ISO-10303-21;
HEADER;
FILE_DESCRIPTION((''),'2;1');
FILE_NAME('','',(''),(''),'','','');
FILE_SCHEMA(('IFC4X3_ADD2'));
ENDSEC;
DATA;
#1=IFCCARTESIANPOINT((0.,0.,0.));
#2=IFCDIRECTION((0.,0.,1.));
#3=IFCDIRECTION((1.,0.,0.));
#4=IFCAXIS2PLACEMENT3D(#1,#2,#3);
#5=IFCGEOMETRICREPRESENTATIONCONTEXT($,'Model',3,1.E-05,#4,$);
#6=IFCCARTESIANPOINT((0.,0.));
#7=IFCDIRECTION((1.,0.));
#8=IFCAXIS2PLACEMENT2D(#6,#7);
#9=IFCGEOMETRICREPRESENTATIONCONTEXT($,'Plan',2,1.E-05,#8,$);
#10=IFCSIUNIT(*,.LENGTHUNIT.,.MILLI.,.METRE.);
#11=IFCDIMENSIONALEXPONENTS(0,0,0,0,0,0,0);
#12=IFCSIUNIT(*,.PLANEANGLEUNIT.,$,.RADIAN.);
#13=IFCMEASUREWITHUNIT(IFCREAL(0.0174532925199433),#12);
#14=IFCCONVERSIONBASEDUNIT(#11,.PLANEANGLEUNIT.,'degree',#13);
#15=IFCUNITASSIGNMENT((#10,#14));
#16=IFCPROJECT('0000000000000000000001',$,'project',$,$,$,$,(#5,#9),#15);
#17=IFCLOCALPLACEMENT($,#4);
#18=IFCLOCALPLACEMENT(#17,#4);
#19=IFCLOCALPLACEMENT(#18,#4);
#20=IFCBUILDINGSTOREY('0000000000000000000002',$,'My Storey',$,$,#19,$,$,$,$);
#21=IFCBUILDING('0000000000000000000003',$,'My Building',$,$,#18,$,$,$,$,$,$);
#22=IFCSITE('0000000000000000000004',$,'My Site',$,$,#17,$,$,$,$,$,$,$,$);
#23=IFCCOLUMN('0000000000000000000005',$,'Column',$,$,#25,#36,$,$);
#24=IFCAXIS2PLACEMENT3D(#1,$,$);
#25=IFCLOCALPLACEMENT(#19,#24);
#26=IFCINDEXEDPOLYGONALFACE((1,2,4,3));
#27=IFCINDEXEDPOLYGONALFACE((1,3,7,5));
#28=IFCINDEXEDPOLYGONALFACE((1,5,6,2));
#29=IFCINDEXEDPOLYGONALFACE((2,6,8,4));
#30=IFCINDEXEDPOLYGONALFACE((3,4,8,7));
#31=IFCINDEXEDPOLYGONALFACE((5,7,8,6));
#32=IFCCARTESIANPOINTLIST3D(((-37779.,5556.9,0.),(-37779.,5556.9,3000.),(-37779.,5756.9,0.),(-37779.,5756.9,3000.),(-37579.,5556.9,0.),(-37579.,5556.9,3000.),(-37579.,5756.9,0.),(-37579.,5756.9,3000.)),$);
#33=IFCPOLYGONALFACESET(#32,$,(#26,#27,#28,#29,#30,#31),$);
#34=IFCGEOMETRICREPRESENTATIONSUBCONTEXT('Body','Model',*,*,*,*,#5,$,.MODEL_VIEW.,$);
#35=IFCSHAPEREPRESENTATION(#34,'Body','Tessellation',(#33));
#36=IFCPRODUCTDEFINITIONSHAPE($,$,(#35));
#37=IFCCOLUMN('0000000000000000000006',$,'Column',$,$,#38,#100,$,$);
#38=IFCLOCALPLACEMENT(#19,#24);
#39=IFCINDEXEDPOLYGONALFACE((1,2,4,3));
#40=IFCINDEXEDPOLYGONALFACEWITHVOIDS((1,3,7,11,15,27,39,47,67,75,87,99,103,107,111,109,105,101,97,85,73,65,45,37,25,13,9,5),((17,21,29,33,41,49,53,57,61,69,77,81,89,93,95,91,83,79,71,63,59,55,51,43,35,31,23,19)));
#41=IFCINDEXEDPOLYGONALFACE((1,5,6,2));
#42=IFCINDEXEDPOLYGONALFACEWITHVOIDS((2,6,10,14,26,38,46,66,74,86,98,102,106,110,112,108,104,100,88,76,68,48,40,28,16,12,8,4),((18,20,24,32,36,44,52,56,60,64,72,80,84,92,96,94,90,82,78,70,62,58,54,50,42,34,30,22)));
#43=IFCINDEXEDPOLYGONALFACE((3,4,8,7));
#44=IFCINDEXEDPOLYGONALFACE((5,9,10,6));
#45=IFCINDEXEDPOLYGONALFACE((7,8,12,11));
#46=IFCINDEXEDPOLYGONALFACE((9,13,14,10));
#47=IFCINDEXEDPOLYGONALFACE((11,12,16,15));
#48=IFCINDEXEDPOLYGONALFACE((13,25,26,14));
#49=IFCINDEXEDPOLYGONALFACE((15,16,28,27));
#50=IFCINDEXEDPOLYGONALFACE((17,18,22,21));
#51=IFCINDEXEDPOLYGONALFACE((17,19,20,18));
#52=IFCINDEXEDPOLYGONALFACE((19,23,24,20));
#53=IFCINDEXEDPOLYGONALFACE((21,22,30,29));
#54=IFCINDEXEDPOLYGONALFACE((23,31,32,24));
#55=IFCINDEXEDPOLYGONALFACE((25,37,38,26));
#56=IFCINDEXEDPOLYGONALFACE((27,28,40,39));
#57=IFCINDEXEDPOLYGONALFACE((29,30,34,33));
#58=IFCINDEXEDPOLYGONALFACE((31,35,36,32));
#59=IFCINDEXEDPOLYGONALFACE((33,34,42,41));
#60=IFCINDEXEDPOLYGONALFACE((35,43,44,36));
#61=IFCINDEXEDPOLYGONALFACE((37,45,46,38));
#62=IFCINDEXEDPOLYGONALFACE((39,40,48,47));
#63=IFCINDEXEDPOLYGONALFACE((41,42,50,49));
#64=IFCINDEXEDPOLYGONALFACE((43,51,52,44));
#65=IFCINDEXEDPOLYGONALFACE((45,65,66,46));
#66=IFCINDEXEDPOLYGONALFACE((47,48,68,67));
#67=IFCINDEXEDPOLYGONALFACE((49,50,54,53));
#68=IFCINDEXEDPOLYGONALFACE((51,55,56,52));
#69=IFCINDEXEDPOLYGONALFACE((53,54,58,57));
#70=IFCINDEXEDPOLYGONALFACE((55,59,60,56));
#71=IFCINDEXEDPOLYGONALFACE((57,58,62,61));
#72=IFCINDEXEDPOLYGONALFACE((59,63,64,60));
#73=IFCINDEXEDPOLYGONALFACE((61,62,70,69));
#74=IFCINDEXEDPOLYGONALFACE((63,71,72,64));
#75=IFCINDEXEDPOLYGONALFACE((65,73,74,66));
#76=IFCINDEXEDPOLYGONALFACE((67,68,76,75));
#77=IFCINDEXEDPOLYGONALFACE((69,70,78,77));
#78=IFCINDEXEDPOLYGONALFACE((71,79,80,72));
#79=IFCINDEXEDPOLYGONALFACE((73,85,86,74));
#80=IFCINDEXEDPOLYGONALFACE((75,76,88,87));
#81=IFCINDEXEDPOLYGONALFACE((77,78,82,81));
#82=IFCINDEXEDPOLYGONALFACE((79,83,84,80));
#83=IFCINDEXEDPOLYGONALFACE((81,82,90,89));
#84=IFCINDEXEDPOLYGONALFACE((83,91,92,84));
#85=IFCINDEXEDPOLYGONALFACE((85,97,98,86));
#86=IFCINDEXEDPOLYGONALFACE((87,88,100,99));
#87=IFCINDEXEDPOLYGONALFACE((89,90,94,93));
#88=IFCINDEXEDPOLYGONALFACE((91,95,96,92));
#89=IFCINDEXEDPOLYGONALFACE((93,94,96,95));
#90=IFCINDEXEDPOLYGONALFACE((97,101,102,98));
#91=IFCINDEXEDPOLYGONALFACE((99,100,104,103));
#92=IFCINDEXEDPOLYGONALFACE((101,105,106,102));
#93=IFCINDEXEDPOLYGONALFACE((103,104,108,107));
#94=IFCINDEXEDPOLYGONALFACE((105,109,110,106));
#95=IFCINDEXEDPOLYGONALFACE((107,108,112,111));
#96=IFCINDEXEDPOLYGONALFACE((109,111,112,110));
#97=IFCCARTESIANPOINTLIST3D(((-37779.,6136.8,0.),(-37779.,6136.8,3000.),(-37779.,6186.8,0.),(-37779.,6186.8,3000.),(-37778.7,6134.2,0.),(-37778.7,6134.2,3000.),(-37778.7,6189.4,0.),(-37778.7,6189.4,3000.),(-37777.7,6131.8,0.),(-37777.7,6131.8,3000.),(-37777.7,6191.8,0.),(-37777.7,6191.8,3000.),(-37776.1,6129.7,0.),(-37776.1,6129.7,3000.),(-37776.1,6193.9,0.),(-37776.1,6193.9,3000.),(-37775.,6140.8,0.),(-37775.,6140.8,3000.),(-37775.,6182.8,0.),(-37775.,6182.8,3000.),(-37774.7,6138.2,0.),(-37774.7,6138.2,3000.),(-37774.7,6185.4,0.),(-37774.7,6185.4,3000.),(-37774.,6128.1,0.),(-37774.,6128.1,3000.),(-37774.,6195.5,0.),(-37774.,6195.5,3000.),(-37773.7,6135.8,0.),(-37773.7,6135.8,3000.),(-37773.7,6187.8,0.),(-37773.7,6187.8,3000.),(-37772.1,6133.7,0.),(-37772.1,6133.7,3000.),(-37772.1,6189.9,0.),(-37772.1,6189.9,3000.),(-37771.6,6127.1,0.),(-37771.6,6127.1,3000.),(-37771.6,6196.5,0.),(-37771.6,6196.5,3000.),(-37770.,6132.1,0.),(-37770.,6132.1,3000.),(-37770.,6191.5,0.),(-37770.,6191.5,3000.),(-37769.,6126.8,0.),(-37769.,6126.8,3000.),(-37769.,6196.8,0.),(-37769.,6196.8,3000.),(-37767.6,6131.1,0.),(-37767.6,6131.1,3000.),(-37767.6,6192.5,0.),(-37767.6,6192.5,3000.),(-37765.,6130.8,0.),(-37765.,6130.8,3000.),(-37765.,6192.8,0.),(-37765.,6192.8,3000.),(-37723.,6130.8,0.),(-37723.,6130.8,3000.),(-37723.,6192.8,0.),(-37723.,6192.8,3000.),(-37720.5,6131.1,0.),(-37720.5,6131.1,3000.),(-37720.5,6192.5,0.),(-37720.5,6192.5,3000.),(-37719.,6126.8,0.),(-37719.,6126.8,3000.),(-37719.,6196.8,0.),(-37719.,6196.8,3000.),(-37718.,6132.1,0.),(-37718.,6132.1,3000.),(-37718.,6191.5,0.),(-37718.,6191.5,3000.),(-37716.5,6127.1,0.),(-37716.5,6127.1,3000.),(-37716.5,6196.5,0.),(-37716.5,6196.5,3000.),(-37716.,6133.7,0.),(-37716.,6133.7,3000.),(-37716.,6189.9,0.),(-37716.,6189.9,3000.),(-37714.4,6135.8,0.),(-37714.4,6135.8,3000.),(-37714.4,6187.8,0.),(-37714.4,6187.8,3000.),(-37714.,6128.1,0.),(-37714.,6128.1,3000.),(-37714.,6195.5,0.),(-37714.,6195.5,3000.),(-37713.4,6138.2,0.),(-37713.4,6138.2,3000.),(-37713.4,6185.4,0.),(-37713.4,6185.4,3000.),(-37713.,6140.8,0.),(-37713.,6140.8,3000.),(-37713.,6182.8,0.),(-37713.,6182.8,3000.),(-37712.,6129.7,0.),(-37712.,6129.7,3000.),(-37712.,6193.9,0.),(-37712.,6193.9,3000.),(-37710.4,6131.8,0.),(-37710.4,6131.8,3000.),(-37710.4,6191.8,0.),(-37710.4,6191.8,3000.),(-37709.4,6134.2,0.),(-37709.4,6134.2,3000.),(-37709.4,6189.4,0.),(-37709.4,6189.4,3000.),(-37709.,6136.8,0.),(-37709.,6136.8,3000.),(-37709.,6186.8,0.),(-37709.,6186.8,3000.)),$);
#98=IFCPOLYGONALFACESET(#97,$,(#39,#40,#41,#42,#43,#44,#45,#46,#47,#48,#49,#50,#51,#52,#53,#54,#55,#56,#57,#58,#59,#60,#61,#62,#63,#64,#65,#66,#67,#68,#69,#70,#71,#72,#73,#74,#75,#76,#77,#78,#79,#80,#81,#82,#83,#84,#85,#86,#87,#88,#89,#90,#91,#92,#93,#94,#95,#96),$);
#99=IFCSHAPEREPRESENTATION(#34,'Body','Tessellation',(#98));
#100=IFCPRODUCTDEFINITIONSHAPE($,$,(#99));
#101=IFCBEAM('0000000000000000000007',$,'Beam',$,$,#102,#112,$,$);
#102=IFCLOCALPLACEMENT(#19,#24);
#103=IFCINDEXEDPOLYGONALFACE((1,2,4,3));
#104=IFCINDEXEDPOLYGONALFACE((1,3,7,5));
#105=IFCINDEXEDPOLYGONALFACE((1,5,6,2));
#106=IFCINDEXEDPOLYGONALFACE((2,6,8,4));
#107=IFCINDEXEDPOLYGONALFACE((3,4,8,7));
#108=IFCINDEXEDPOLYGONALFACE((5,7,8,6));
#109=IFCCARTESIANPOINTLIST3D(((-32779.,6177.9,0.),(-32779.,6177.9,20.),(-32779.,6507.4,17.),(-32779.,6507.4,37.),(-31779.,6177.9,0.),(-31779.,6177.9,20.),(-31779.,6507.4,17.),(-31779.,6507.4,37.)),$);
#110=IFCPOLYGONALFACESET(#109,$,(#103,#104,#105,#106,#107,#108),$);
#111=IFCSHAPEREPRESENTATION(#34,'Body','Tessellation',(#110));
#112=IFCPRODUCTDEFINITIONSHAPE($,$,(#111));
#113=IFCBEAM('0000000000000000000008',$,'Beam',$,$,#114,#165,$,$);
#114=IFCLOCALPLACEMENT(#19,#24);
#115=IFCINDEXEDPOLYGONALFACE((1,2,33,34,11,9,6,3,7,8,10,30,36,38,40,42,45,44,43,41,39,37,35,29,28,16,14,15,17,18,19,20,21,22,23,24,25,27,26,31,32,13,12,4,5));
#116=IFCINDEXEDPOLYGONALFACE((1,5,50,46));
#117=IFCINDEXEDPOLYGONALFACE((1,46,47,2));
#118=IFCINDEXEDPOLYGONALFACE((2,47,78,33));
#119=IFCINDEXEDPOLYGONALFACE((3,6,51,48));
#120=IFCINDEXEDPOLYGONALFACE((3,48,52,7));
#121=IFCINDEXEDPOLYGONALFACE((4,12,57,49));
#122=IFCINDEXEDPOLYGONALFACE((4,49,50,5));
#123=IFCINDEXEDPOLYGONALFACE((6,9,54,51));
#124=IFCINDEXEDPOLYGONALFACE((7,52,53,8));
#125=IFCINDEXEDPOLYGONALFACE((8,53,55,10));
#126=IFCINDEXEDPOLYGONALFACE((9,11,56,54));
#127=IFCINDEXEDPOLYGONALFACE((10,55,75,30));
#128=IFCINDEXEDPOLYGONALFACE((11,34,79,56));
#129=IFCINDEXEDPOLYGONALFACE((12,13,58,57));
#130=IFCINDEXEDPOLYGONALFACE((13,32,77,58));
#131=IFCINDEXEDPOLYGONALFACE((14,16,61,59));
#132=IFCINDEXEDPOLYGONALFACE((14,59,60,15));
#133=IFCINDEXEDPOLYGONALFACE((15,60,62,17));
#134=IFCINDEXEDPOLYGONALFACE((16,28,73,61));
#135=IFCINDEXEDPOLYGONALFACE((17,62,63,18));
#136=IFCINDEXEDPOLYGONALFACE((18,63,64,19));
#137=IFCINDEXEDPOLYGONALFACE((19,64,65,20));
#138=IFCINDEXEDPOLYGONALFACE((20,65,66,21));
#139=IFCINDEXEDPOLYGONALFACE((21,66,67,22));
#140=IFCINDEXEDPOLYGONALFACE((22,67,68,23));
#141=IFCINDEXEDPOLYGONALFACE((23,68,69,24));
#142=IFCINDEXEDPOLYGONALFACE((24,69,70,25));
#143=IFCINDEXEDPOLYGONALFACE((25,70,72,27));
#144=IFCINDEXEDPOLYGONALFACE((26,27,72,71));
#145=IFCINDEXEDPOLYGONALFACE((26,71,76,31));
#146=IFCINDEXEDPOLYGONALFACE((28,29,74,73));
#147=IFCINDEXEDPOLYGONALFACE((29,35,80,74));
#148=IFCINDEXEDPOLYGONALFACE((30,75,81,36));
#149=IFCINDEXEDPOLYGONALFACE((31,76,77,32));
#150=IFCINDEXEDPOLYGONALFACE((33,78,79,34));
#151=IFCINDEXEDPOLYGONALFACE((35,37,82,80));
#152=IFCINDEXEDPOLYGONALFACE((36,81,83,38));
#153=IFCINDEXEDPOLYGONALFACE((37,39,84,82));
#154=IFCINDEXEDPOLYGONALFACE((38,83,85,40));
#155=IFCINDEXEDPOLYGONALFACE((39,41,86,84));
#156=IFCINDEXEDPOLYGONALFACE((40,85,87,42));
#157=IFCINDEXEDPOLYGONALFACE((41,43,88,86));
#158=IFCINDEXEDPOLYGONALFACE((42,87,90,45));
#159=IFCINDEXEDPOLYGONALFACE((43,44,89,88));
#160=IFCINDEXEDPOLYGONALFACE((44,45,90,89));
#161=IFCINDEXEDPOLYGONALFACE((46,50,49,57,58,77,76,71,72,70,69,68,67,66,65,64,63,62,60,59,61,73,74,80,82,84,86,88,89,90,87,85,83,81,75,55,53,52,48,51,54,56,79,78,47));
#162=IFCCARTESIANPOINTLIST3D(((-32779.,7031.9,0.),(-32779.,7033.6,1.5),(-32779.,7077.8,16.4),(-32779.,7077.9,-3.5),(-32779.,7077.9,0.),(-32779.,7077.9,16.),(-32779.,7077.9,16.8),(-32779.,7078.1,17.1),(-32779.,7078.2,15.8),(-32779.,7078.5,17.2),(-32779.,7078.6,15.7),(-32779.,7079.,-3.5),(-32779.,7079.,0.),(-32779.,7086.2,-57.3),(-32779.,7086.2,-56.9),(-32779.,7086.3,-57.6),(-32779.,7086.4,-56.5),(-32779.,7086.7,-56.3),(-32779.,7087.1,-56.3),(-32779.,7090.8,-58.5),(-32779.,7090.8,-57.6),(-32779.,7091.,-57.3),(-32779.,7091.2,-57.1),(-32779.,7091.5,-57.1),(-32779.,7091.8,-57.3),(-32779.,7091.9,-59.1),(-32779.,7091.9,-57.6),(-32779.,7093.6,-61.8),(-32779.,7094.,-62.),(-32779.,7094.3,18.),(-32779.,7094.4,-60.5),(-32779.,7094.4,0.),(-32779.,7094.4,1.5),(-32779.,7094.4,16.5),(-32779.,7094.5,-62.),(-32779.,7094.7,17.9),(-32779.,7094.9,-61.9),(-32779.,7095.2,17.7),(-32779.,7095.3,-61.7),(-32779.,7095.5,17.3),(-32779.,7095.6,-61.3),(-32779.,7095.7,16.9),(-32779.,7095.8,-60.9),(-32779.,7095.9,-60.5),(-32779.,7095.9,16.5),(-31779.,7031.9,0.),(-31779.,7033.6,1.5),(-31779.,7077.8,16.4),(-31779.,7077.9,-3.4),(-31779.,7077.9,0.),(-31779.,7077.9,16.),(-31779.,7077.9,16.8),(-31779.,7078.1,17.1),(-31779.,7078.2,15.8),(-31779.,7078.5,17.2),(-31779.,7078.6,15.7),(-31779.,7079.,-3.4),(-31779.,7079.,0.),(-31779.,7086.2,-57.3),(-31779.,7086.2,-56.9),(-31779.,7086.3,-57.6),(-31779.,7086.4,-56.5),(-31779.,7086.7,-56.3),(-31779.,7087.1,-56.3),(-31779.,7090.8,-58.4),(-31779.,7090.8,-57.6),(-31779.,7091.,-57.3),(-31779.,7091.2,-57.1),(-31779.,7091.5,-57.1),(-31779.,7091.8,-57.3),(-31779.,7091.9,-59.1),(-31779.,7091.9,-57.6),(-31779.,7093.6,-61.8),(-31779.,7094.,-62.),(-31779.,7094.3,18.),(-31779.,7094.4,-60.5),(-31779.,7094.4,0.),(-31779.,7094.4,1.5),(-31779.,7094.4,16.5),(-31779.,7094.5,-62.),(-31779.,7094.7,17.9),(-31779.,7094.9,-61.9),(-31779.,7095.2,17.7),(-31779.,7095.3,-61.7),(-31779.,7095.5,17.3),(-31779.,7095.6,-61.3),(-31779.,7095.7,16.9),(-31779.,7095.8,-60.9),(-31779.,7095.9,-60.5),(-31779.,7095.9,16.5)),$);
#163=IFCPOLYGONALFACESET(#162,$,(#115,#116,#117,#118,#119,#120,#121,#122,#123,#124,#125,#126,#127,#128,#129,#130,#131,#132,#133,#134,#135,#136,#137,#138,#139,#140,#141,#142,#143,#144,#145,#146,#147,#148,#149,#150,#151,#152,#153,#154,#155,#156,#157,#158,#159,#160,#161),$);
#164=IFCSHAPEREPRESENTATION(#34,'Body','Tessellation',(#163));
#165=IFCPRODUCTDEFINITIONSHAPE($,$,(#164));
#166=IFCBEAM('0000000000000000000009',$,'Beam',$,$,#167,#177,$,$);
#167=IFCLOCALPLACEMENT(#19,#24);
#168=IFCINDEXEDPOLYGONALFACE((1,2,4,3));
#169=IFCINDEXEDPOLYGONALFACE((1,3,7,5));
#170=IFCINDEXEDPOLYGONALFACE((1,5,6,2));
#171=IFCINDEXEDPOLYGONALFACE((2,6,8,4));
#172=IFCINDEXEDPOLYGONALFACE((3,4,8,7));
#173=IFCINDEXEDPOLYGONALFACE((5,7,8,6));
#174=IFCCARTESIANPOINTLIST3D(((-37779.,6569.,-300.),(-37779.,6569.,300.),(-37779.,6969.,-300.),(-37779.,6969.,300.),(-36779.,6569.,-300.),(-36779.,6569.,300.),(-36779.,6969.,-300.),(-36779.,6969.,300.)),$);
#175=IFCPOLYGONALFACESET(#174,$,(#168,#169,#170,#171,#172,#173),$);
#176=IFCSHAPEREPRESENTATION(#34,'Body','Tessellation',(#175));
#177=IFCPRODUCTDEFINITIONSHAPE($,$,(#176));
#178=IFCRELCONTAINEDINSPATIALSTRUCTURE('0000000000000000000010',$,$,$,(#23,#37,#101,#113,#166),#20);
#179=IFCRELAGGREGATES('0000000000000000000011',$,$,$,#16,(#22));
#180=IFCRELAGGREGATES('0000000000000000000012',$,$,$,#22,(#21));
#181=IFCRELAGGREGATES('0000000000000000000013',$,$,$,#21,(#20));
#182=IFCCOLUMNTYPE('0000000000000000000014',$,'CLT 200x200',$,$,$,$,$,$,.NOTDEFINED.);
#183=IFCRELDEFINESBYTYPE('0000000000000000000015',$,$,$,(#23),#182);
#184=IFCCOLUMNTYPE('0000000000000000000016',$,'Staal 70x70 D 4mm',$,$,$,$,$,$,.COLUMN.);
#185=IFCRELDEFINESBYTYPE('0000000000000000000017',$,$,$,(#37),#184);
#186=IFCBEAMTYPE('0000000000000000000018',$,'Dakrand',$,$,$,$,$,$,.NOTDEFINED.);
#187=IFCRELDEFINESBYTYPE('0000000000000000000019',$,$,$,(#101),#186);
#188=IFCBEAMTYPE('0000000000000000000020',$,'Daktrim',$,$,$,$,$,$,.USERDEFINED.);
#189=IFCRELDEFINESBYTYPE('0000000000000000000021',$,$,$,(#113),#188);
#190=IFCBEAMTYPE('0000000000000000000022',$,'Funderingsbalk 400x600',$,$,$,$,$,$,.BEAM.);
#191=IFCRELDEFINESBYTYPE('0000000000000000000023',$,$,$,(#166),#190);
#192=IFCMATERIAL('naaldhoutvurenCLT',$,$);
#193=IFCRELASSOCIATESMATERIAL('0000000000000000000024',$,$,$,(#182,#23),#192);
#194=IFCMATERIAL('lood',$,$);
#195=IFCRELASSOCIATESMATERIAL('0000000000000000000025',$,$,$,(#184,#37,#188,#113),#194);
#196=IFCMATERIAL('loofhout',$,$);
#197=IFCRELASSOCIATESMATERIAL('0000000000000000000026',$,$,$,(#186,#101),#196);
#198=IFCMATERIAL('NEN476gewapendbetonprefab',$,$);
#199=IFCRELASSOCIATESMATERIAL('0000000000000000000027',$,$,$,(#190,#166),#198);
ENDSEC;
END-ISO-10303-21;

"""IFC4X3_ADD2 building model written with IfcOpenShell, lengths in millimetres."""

from ifc_helpers import new_model, entity, si_unit, converted_unit, frame, origin_with_axes, origin_2d_with_axis, place, context, subcontext, project, spatial, line, arc, indexed_curve, rectangle, hollow_rectangle, outline, extrude, material, material_profile, profile_set, profile_usage, type_object, element, save


model = new_model("IFC4X3_ADD2")

# Units and contexts
model_context = context("Model", 3, precision=1e-05, world=origin_with_axes())
plan_context = context("Plan", 2, precision=1e-05, world=origin_2d_with_axis())
body_context = subcontext(model_context, "Body", "Model", "MODEL_VIEW")
ifc_project = project(units=[si_unit("LENGTHUNIT", "METRE", prefix="MILLI"), converted_unit("PLANEANGLEUNIT", "degree", entity("IfcReal", 0.0174532925199433), si_unit("PLANEANGLEUNIT", "RADIAN"), dimensions=[0, 0, 0, 0, 0, 0, 0])], contexts=[model_context, plan_context])

# Site, building, storey
site_placement = place(None, origin_with_axes())
site = spatial("IfcSite", under=ifc_project, at=site_placement, Name="My Site")
building_placement = place(site_placement, origin_with_axes())
building = spatial("IfcBuilding", under=site, at=building_placement, Name="My Building")
storey_placement = place(building_placement, origin_with_axes())
storey = spatial("IfcBuildingStorey", under=building, at=storey_placement, Name="My Storey")

# Columns
ifc_material_1 = material(Name="naaldhoutvurenCLT")
ifc_material_profile_1 = material_profile(ifc_material_1, rectangle(XDim=200.0, YDim=200.0))
ifc_profile_set_1 = profile_set([ifc_material_profile_1], Name="naaldhoutvurenCLT")
ifc_profile_usage_1 = profile_usage(ifc_profile_set_1, cardinal=5)
column_type_1 = type_object("IfcColumnType", Name="CLT 200x200", PredefinedType="NOTDEFINED", material=ifc_profile_set_1)
column_1_placement = place(storey_placement, frame((-37679.0, 5656.9, 0.0), z_axis=(0.0, 0.0, 1.0), x_axis=(1.0, 0.0, 0.0)))
element("IfcColumn", 1, at=column_1_placement, inside=storey, type_object=column_type_1, material=ifc_profile_usage_1, Name="Column", context=body_context, shape_type="SweptSolid", body=[
    extrude(rectangle(XDim=200.0, YDim=200.0), origin_with_axes(), (0.0, 0.0, 1.0), 3000.0),
])
ifc_material_2 = material(Name="lood")
ifc_material_profile_2 = material_profile(ifc_material_2, hollow_rectangle(XDim=70.0, YDim=70.0, WallThickness=4.0, InnerFilletRadius=10.0, OuterFilletRadius=10.0))
ifc_profile_set_2 = profile_set([ifc_material_profile_2], Name="lood")
ifc_profile_usage_2 = profile_usage(ifc_profile_set_2, cardinal=5)
column_type_2 = type_object("IfcColumnType", Name="Staal 70x70 D 4mm", PredefinedType="COLUMN", material=ifc_profile_set_2)
column_2_placement = place(storey_placement, frame((-37744.0, 6161.8, 0.0), z_axis=(0.0, 0.0, 1.0), x_axis=(1.0, 0.0, 0.0)))
element("IfcColumn", 2, at=column_2_placement, inside=storey, type_object=column_type_2, material=ifc_profile_usage_2, Name="Column", context=body_context, shape_type="SweptSolid", body=[
    extrude(hollow_rectangle(XDim=70.0, YDim=70.0, WallThickness=4.0, InnerFilletRadius=10.0, OuterFilletRadius=10.0), origin_with_axes(), (0.0, 0.0, 1.0), 3000.0),
])

# Beams
ifc_material_3 = material(Name="loofhout")
ifc_material_profile_3 = material_profile(ifc_material_3, outline(indexed_curve([(329.6, 37.0), (329.6, 17.0), (0.0, 0.0), (0.0, 20.0)], segments=[line(3, 2), line(2, 1), line(1, 4), line(4, 3)], self_intersect=False)))
ifc_profile_set_3 = profile_set([ifc_material_profile_3], Name="loofhout")
ifc_profile_usage_3 = profile_usage(ifc_profile_set_3)
beam_type_1 = type_object("IfcBeamType", Name="Dakrand", PredefinedType="NOTDEFINED", material=ifc_profile_set_3)
beam_1_placement = place(storey_placement, frame((-32779.0, 6177.9, 0.0), z_axis=(1.0, 0.0, 0.0), x_axis=(0.0, 1.0, 0.0)))
element("IfcBeam", 3, at=beam_1_placement, inside=storey, type_object=beam_type_1, material=ifc_profile_usage_3, Name="Beam", context=body_context, shape_type="SweptSolid", body=[
    extrude(outline(indexed_curve([(329.6, 37.0), (329.6, 17.0), (0.0, 0.0), (0.0, 20.0)], segments=[line(3, 2), line(2, 1), line(1, 4), line(4, 3)], self_intersect=False)), origin_with_axes(), (0.0, 0.0, 1.0), 1000.0),
])
ifc_material_profile_4 = material_profile(ifc_material_2, outline(indexed_curve([(12.9, -58.5), (12.9, -57.6), (13.5, -57.1), (14.1, -57.6), (14.1, -59.1), (16.5, -60.5), (16.5, 0.0), (1.1, 0.0), (1.1, -3.5), (0.0, -3.5), (0.0, 0.0), (-46.0, 0.0), (-44.3, 1.5), (16.5, 1.5), (16.5, 16.5), (0.7, 15.7), (-0.1, 16.4), (0.6, 17.2), (16.4, 18.0), (17.6, 17.3), (18.0, 16.5), (18.0, -60.5), (17.2, -61.8), (15.8, -61.8), (8.5, -57.6), (8.4, -56.7), (9.2, -56.3)], segments=[line(10, 9), line(9, 8), line(8, 7), line(7, 6), line(6, 5), line(5, 4), arc(4, 3, 2), line(2, 1), line(1, 27), arc(27, 26, 25), line(25, 24), arc(24, 23, 22), line(22, 21), arc(21, 20, 19), line(19, 18), arc(18, 17, 16), line(16, 15), line(15, 14), line(14, 13), line(13, 12), line(12, 11), line(11, 10)], self_intersect=False)))
ifc_profile_set_4 = profile_set([ifc_material_profile_4], Name="lood")
ifc_profile_usage_4 = profile_usage(ifc_profile_set_4, cardinal=5)
beam_type_2 = type_object("IfcBeamType", Name="Daktrim", PredefinedType="USERDEFINED", material=ifc_profile_set_4)
beam_2_placement = place(storey_placement, frame((-32779.0, 7077.9, 0.0), z_axis=(1.0, 0.0, 0.0), x_axis=(0.0, 1.0, 0.0)))
element("IfcBeam", 4, at=beam_2_placement, inside=storey, type_object=beam_type_2, material=ifc_profile_usage_4, Name="Beam", context=body_context, shape_type="SweptSolid", body=[
    extrude(outline(indexed_curve([(12.9, -58.5), (12.9, -57.6), (13.5, -57.1), (14.1, -57.6), (14.1, -59.1), (16.5, -60.5), (16.5, 0.0), (1.1, 0.0), (1.1, -3.5), (0.0, -3.5), (0.0, 0.0), (-46.0, 0.0), (-44.3, 1.5), (16.5, 1.5), (16.5, 16.5), (0.7, 15.7), (-0.1, 16.4), (0.6, 17.2), (16.4, 18.0), (17.6, 17.3), (18.0, 16.5), (18.0, -60.5), (17.2, -61.8), (15.8, -61.8), (8.5, -57.6), (8.4, -56.7), (9.2, -56.3)], segments=[line(10, 9), line(9, 8), line(8, 7), line(7, 6), line(6, 5), line(5, 4), arc(4, 3, 2), line(2, 1), line(1, 27), arc(27, 26, 25), line(25, 24), arc(24, 23, 22), line(22, 21), arc(21, 20, 19), line(19, 18), arc(18, 17, 16), line(16, 15), line(15, 14), line(14, 13), line(13, 12), line(12, 11), line(11, 10)], self_intersect=False)), origin_with_axes(), (0.0, 0.0, 1.0), 1000.0),
])
ifc_material_4 = material(Name="NEN476gewapendbetonprefab")
ifc_material_profile_5 = material_profile(ifc_material_4, rectangle(XDim=400.0, YDim=600.0))
ifc_profile_set_5 = profile_set([ifc_material_profile_5], Name="gewapendbetonprefab")
ifc_profile_usage_5 = profile_usage(ifc_profile_set_5, cardinal=5)
beam_type_3 = type_object("IfcBeamType", Name="Funderingsbalk 400x600", PredefinedType="BEAM", material=ifc_profile_set_5)
beam_3_placement = place(storey_placement, frame((-37779.0, 6769.0, 0.0), z_axis=(1.0, 0.0, 0.0), x_axis=(0.0, 1.0, 0.0)))
element("IfcBeam", 5, at=beam_3_placement, inside=storey, type_object=beam_type_3, material=ifc_profile_usage_5, Name="Beam", context=body_context, shape_type="SweptSolid", body=[
    extrude(rectangle(XDim=400.0, YDim=600.0), origin_with_axes(), (0.0, 0.0, 1.0), 1000.0),
])

save(model, "model.ifc")
